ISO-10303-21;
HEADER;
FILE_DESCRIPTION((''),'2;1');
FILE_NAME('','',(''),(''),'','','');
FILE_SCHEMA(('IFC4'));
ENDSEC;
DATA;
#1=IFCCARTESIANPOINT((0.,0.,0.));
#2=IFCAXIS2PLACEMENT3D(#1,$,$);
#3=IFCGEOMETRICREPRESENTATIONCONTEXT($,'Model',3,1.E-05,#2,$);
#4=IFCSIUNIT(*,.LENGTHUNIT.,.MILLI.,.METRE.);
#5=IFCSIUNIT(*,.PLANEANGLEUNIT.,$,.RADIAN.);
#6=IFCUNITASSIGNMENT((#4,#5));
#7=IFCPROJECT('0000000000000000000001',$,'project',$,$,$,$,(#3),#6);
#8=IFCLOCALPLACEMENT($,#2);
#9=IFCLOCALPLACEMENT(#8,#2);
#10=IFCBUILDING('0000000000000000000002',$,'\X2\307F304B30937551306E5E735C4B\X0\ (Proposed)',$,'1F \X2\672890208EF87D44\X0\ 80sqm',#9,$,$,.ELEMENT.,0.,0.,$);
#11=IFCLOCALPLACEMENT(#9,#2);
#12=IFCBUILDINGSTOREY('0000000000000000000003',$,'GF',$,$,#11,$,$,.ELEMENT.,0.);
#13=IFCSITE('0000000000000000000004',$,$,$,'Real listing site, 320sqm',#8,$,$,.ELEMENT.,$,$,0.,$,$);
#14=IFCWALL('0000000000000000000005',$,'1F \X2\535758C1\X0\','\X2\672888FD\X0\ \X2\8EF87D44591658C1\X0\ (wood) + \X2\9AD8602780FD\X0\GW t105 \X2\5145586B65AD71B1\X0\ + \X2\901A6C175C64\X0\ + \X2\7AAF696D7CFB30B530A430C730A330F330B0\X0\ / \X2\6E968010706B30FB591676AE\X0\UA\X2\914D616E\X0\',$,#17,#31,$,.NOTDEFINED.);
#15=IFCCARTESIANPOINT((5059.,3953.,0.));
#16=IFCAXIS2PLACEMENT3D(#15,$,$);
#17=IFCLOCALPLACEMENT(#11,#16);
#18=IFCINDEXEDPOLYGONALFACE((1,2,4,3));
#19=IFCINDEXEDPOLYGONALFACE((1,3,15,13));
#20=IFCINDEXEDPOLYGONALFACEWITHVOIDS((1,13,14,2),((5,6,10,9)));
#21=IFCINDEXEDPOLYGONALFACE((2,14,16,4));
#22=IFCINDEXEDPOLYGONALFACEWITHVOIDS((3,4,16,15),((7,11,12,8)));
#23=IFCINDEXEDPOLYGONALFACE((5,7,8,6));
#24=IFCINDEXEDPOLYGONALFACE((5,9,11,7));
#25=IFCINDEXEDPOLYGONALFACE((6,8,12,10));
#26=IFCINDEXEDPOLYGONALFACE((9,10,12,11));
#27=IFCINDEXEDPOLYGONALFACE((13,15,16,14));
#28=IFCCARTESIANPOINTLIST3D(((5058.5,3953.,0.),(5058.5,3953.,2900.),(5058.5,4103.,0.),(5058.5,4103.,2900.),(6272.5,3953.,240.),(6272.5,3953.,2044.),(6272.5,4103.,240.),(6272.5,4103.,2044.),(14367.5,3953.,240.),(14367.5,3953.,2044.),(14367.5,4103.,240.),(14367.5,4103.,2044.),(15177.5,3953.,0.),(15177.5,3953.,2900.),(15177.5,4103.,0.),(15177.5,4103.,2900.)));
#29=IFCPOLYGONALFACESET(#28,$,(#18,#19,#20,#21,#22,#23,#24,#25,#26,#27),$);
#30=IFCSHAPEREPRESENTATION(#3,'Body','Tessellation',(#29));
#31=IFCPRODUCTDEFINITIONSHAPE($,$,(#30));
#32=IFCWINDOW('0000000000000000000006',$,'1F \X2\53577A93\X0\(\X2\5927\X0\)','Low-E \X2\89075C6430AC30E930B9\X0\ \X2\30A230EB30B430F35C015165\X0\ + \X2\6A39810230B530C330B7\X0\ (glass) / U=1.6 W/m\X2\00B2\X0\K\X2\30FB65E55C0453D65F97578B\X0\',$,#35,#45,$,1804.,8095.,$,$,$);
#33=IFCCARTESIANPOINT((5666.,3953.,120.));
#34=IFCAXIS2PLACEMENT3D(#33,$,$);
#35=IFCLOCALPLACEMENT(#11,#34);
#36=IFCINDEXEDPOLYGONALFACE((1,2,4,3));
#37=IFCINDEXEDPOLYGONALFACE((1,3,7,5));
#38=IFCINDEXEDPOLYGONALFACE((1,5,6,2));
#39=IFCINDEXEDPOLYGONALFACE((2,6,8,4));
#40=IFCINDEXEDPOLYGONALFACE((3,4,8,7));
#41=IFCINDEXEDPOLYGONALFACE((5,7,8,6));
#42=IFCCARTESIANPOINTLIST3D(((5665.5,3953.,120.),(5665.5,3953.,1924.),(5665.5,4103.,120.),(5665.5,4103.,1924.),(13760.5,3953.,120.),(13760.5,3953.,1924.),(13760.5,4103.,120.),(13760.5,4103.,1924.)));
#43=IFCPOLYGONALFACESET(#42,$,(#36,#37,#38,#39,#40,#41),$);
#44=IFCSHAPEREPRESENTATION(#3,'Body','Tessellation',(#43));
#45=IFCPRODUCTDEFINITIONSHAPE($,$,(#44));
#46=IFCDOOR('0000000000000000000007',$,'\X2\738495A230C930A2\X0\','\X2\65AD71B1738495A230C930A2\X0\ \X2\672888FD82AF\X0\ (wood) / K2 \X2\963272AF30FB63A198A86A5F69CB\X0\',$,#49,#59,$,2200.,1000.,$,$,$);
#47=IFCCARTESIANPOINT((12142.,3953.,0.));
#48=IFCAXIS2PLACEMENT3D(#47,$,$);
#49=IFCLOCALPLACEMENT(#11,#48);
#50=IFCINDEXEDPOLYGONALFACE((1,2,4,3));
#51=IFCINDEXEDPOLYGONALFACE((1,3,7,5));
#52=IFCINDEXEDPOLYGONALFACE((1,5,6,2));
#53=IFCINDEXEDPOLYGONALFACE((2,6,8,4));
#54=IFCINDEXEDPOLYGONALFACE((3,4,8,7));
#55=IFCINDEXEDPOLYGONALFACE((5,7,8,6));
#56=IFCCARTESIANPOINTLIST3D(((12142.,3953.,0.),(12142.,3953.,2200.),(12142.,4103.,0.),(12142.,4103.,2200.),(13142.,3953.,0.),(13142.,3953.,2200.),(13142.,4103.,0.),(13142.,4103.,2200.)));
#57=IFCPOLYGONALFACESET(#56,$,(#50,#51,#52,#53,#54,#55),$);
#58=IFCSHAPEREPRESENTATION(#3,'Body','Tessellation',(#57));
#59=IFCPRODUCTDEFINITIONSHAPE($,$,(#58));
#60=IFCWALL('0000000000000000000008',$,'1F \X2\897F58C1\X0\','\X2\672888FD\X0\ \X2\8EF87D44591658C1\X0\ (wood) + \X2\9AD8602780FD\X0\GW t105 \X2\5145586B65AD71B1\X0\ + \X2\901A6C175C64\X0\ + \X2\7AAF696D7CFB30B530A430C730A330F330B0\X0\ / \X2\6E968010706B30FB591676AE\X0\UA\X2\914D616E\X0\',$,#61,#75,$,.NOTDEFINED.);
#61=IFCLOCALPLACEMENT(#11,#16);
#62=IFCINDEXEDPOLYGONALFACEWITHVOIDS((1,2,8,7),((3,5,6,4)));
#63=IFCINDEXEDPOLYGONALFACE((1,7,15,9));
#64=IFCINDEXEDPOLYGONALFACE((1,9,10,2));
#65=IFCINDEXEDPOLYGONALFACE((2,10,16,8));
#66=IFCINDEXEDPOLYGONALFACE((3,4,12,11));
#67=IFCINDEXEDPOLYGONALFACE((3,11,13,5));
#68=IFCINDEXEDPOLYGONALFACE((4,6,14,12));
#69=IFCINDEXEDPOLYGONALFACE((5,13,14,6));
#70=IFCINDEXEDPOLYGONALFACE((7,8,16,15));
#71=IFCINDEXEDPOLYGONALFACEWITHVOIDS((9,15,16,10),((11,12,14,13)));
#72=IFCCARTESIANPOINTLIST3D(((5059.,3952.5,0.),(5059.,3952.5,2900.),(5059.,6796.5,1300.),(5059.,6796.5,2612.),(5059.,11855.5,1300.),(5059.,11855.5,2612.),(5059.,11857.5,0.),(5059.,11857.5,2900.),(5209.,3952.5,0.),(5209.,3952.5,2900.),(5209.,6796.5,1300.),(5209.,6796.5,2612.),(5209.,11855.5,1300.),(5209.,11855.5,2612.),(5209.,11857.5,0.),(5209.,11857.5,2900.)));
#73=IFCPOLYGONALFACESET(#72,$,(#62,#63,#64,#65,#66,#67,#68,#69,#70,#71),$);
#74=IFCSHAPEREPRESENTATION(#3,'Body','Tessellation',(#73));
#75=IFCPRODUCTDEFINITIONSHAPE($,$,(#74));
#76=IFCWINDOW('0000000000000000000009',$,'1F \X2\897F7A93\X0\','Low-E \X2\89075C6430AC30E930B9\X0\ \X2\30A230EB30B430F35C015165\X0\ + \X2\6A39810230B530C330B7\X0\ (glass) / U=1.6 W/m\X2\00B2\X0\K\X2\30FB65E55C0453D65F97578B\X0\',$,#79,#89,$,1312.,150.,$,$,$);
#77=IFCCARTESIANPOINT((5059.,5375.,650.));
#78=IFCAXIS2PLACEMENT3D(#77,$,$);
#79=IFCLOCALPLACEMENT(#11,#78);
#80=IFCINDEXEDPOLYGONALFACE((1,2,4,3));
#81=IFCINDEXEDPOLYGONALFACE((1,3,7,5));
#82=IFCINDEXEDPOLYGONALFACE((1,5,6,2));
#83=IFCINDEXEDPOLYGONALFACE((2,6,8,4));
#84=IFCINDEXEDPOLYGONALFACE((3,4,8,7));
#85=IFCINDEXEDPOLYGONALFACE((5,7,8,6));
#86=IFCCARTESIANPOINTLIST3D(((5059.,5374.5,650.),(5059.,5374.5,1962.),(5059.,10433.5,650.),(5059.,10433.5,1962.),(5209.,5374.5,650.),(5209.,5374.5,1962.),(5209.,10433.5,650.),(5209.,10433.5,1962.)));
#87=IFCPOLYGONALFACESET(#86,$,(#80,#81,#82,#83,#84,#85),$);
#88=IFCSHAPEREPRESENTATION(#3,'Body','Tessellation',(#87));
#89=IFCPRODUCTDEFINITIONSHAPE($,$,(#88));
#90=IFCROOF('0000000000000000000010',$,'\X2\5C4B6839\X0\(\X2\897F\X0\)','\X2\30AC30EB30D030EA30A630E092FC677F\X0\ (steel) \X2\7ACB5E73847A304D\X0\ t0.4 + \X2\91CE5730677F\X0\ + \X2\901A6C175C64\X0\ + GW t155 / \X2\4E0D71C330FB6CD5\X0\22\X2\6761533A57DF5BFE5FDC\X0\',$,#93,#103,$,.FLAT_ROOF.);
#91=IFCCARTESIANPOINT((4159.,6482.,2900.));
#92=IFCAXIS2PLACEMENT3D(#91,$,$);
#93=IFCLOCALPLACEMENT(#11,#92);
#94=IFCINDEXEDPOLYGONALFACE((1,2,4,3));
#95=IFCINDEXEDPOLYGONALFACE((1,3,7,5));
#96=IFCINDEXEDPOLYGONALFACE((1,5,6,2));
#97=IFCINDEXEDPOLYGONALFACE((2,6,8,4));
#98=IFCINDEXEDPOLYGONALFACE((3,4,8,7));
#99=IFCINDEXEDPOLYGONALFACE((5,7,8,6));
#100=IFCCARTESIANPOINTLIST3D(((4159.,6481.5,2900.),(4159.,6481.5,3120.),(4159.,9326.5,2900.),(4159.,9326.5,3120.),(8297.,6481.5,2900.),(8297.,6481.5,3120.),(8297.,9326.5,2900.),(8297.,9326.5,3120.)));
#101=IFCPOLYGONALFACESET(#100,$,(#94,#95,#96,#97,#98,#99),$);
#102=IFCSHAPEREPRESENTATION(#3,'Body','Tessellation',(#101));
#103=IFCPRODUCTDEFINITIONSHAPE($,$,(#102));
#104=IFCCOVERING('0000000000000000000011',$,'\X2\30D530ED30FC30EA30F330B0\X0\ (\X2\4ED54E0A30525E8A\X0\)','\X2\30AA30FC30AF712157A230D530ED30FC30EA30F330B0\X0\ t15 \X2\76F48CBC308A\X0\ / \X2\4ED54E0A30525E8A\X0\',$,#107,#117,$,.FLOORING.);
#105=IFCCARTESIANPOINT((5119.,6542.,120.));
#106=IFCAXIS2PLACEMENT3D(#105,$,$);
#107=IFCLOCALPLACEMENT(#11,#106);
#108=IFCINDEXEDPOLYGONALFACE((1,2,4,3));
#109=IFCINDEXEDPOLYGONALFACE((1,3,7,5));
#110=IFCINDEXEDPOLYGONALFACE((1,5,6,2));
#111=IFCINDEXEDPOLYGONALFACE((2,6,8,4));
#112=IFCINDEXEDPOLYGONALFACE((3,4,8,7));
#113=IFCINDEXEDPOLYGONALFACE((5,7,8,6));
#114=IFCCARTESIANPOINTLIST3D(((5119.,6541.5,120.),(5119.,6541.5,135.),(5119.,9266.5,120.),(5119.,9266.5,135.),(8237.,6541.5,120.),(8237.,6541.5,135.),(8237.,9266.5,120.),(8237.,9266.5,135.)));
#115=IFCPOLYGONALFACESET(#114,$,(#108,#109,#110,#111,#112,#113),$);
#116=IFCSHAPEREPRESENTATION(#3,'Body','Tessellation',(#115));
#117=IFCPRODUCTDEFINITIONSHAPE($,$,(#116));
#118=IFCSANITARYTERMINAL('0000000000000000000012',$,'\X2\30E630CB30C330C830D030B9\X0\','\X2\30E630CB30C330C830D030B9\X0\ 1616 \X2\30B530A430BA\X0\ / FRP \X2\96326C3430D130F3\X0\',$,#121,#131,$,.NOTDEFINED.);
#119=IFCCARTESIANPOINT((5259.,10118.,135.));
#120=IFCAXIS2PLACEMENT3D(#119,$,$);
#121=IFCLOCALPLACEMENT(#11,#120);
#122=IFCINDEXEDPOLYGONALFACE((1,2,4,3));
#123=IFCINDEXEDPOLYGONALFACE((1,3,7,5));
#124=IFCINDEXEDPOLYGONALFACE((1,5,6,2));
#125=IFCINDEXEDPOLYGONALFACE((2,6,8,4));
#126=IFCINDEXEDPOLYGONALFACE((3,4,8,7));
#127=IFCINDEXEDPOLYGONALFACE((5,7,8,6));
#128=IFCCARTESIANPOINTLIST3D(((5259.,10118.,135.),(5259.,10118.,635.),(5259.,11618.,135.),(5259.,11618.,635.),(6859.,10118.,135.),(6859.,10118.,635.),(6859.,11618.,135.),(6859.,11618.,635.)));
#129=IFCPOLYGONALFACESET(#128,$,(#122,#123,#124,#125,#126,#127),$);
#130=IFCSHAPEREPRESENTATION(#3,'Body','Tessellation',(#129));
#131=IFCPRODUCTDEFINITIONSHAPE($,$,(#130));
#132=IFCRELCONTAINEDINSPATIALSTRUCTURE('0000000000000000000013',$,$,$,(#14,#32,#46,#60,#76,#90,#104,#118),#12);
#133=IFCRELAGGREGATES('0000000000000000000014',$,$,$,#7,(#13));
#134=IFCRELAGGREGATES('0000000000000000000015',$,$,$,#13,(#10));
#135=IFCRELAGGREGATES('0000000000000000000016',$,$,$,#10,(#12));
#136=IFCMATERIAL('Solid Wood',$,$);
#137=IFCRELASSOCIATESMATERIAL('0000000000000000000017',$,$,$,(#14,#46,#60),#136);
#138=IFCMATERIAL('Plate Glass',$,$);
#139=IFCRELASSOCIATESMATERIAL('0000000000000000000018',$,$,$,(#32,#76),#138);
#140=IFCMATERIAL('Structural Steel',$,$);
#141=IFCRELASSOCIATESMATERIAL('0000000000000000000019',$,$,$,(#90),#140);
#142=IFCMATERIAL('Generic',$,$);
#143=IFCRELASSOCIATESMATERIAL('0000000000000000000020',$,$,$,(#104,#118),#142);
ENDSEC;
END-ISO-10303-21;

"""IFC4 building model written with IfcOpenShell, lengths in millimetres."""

from ifc_helpers import new_model, si_unit, frame, frame_2d, origin, place, context, project, spatial, rectangle, extrude, material, element, fill, save


model = new_model("IFC4")

# Units and contexts
model_context = context("Model", 3, precision=1e-05, world=origin())
ifc_project = project(units=[si_unit("LENGTHUNIT", "METRE", prefix="MILLI"), si_unit("PLANEANGLEUNIT", "RADIAN")], contexts=[model_context])

# Site, building, storey
site_placement = place(None, origin())
site = spatial("IfcSite", under=ifc_project, at=site_placement, ObjectType="Real listing site, 320sqm", CompositionType="ELEMENT", RefElevation=0.0)
building_placement = place(site_placement, origin())
building = spatial("IfcBuilding", under=site, at=building_placement, Name="みかん畑の平屋 (Proposed)", ObjectType="1F 木造軸組 80sqm", CompositionType="ELEMENT", ElevationOfRefHeight=0.0, ElevationOfTerrain=0.0)
storey_placement = place(building_placement, origin())
storey = spatial("IfcBuildingStorey", under=building, at=storey_placement, Name="GF", CompositionType="ELEMENT", Elevation=0.0)

# Shared definitions
ifc_material_1 = material(Name="Solid Wood")

# Wall, openings, window, door
wall_1_placement = place(storey_placement, frame((5059.0, 3953.0, 0.0)))
wall_1 = element("IfcWall", 1, at=wall_1_placement, inside=storey, material=ifc_material_1, Name="1F 南壁", Description="木製 軸組外壁 (wood) + 高性能GW t105 充填断熱 + 通気層 + 窯業系サイディング / 準耐火・外皮UA配慮", PredefinedType="NOTDEFINED", context=model_context, shape_type="SweptSolid", body=[
    extrude(rectangle(XDim=10119.0, YDim=150.0, at=frame_2d((5059.0, 75.0))), frame((5059.0, 3953.0, 0.0)), (0.0, 0.0, 1.0), 2900.0),
])
opening_1_placement = place(storey_placement, frame((5666.0, 3953.0, 120.0)))
opening_1 = element("IfcOpeningElement", 2, at=opening_1_placement, cuts=wall_1, PredefinedType="NOTDEFINED", context=model_context, shape_type="SweptSolid", body=[
    extrude(rectangle(XDim=8095.0, YDim=150.0, at=frame_2d((4047.0, 75.0))), frame((5666.0, 3953.0, 120.0)), (0.0, 0.0, 1.0), 1804.0),
])
opening_2_placement = place(storey_placement, frame((12142.0, 3953.0, 0.0)))
opening_2 = element("IfcOpeningElement", 3, at=opening_2_placement, cuts=wall_1, PredefinedType="NOTDEFINED", context=model_context, shape_type="SweptSolid", body=[
    extrude(rectangle(XDim=1000.0, YDim=150.0, at=frame_2d((500.0, 75.0))), frame((12142.0, 3953.0, 0.0)), (0.0, 0.0, 1.0), 2200.0),
])
ifc_material_2 = material(Name="Plate Glass")
window_1_placement = place(storey_placement, frame((5666.0, 3953.0, 120.0)))
window_1 = element("IfcWindow", 4, at=window_1_placement, inside=storey, material=ifc_material_2, Name="1F 南窓(大)", Description="Low-E 複層ガラス アルゴン封入 + 樹脂サッシ (glass) / U=1.6 W/m²K・日射取得型", OverallHeight=1804.0, OverallWidth=8095.0, context=model_context, shape_type="SweptSolid", body=[
    extrude(rectangle(XDim=8095.0, YDim=150.0, at=frame_2d((4047.0, 75.0))), frame((5666.0, 3953.0, 120.0)), (0.0, 0.0, 1.0), 1804.0),
])
fill(opening_1, window_1)
door_placement = place(storey_placement, frame((12142.0, 3953.0, 0.0)))
door = element("IfcDoor", 5, at=door_placement, inside=storey, material=ifc_material_1, Name="玄関ドア", Description="断熱玄関ドア 木製芯 (wood) / K2 防犯・採風機構", OverallHeight=2200.0, OverallWidth=1000.0, context=model_context, shape_type="SweptSolid", body=[
    extrude(rectangle(XDim=1000.0, YDim=150.0, at=frame_2d((500.0, 75.0))), frame((12142.0, 3953.0, 0.0)), (0.0, 0.0, 1.0), 2200.0),
])
fill(opening_2, door)

# Wall, opening, window
wall_2_placement = place(storey_placement, frame((5059.0, 3953.0, 0.0)))
wall_2 = element("IfcWall", 6, at=wall_2_placement, inside=storey, material=ifc_material_1, Name="1F 西壁", Description="木製 軸組外壁 (wood) + 高性能GW t105 充填断熱 + 通気層 + 窯業系サイディング / 準耐火・外皮UA配慮", PredefinedType="NOTDEFINED", context=model_context, shape_type="SweptSolid", body=[
    extrude(rectangle(XDim=150.0, YDim=7905.0, at=frame_2d((75.0, 3952.0))), frame((5059.0, 3953.0, 0.0)), (0.0, 0.0, 1.0), 2900.0),
])
opening_3_placement = place(storey_placement, frame((5059.0, 5375.0, 650.0)))
opening_3 = element("IfcOpeningElement", 7, at=opening_3_placement, cuts=wall_2, PredefinedType="NOTDEFINED", context=model_context, shape_type="SweptSolid", body=[
    extrude(rectangle(XDim=150.0, YDim=5059.0, at=frame_2d((75.0, 2529.0))), frame((5059.0, 5375.0, 650.0)), (0.0, 0.0, 1.0), 1312.0),
])
window_2_placement = place(storey_placement, frame((5059.0, 5375.0, 650.0)))
window_2 = element("IfcWindow", 8, at=window_2_placement, inside=storey, material=ifc_material_2, Name="1F 西窓", Description="Low-E 複層ガラス アルゴン封入 + 樹脂サッシ (glass) / U=1.6 W/m²K・日射取得型", OverallHeight=1312.0, OverallWidth=150.0, context=model_context, shape_type="SweptSolid", body=[
    extrude(rectangle(XDim=150.0, YDim=5059.0, at=frame_2d((75.0, 2529.0))), frame((5059.0, 5375.0, 650.0)), (0.0, 0.0, 1.0), 1312.0),
])
fill(opening_3, window_2)

# Roof
ifc_material_3 = material(Name="Structural Steel")
roof_1_placement = place(storey_placement, frame((4159.0, 6482.0, 2900.0)))
element("IfcRoof", 9, at=roof_1_placement, inside=storey, material=ifc_material_3, Name="屋根(西)", Description="ガルバリウム鋼板 (steel) 立平葺き t0.4 + 野地板 + 通気層 + GW t155 / 不燃・法22条区域対応", PredefinedType="FLAT_ROOF", context=model_context, shape_type="SweptSolid", body=[
    extrude(rectangle(XDim=4138.0, YDim=2845.0, at=frame_2d((2069.0, 1422.0))), frame((4159.0, 6482.0, 2900.0)), (0.0, 0.0, 1.0), 220.0),
])

# Covering
ifc_material_4 = material(Name="Generic")
covering_1_placement = place(storey_placement, frame((5119.0, 6542.0, 120.0)))
element("IfcCovering", 10, at=covering_1_placement, inside=storey, material=ifc_material_4, Name="フローリング (仕上げ床)", Description="オーク無垢フローリング t15 直貼り / 仕上げ床", PredefinedType="FLOORING", context=model_context, shape_type="SweptSolid", body=[
    extrude(rectangle(XDim=3118.0, YDim=2725.0, at=frame_2d((1559.0, 1362.0))), frame((5119.0, 6542.0, 120.0)), (0.0, 0.0, 1.0), 15.0),
])

# Sanitary terminal
sanitary_terminal_placement = place(storey_placement, frame((5259.0, 10118.0, 135.0)))
element("IfcSanitaryTerminal", 11, at=sanitary_terminal_placement, inside=storey, material=ifc_material_4, Name="ユニットバス", Description="ユニットバス 1616 サイズ / FRP 防水パン", PredefinedType="NOTDEFINED", context=model_context, shape_type="SweptSolid", body=[
    extrude(rectangle(XDim=1600.0, YDim=1500.0, at=frame_2d((800.0, 750.0))), frame((5259.0, 10118.0, 135.0)), (0.0, 0.0, 1.0), 500.0),
])

save(model, "model.ifc")
